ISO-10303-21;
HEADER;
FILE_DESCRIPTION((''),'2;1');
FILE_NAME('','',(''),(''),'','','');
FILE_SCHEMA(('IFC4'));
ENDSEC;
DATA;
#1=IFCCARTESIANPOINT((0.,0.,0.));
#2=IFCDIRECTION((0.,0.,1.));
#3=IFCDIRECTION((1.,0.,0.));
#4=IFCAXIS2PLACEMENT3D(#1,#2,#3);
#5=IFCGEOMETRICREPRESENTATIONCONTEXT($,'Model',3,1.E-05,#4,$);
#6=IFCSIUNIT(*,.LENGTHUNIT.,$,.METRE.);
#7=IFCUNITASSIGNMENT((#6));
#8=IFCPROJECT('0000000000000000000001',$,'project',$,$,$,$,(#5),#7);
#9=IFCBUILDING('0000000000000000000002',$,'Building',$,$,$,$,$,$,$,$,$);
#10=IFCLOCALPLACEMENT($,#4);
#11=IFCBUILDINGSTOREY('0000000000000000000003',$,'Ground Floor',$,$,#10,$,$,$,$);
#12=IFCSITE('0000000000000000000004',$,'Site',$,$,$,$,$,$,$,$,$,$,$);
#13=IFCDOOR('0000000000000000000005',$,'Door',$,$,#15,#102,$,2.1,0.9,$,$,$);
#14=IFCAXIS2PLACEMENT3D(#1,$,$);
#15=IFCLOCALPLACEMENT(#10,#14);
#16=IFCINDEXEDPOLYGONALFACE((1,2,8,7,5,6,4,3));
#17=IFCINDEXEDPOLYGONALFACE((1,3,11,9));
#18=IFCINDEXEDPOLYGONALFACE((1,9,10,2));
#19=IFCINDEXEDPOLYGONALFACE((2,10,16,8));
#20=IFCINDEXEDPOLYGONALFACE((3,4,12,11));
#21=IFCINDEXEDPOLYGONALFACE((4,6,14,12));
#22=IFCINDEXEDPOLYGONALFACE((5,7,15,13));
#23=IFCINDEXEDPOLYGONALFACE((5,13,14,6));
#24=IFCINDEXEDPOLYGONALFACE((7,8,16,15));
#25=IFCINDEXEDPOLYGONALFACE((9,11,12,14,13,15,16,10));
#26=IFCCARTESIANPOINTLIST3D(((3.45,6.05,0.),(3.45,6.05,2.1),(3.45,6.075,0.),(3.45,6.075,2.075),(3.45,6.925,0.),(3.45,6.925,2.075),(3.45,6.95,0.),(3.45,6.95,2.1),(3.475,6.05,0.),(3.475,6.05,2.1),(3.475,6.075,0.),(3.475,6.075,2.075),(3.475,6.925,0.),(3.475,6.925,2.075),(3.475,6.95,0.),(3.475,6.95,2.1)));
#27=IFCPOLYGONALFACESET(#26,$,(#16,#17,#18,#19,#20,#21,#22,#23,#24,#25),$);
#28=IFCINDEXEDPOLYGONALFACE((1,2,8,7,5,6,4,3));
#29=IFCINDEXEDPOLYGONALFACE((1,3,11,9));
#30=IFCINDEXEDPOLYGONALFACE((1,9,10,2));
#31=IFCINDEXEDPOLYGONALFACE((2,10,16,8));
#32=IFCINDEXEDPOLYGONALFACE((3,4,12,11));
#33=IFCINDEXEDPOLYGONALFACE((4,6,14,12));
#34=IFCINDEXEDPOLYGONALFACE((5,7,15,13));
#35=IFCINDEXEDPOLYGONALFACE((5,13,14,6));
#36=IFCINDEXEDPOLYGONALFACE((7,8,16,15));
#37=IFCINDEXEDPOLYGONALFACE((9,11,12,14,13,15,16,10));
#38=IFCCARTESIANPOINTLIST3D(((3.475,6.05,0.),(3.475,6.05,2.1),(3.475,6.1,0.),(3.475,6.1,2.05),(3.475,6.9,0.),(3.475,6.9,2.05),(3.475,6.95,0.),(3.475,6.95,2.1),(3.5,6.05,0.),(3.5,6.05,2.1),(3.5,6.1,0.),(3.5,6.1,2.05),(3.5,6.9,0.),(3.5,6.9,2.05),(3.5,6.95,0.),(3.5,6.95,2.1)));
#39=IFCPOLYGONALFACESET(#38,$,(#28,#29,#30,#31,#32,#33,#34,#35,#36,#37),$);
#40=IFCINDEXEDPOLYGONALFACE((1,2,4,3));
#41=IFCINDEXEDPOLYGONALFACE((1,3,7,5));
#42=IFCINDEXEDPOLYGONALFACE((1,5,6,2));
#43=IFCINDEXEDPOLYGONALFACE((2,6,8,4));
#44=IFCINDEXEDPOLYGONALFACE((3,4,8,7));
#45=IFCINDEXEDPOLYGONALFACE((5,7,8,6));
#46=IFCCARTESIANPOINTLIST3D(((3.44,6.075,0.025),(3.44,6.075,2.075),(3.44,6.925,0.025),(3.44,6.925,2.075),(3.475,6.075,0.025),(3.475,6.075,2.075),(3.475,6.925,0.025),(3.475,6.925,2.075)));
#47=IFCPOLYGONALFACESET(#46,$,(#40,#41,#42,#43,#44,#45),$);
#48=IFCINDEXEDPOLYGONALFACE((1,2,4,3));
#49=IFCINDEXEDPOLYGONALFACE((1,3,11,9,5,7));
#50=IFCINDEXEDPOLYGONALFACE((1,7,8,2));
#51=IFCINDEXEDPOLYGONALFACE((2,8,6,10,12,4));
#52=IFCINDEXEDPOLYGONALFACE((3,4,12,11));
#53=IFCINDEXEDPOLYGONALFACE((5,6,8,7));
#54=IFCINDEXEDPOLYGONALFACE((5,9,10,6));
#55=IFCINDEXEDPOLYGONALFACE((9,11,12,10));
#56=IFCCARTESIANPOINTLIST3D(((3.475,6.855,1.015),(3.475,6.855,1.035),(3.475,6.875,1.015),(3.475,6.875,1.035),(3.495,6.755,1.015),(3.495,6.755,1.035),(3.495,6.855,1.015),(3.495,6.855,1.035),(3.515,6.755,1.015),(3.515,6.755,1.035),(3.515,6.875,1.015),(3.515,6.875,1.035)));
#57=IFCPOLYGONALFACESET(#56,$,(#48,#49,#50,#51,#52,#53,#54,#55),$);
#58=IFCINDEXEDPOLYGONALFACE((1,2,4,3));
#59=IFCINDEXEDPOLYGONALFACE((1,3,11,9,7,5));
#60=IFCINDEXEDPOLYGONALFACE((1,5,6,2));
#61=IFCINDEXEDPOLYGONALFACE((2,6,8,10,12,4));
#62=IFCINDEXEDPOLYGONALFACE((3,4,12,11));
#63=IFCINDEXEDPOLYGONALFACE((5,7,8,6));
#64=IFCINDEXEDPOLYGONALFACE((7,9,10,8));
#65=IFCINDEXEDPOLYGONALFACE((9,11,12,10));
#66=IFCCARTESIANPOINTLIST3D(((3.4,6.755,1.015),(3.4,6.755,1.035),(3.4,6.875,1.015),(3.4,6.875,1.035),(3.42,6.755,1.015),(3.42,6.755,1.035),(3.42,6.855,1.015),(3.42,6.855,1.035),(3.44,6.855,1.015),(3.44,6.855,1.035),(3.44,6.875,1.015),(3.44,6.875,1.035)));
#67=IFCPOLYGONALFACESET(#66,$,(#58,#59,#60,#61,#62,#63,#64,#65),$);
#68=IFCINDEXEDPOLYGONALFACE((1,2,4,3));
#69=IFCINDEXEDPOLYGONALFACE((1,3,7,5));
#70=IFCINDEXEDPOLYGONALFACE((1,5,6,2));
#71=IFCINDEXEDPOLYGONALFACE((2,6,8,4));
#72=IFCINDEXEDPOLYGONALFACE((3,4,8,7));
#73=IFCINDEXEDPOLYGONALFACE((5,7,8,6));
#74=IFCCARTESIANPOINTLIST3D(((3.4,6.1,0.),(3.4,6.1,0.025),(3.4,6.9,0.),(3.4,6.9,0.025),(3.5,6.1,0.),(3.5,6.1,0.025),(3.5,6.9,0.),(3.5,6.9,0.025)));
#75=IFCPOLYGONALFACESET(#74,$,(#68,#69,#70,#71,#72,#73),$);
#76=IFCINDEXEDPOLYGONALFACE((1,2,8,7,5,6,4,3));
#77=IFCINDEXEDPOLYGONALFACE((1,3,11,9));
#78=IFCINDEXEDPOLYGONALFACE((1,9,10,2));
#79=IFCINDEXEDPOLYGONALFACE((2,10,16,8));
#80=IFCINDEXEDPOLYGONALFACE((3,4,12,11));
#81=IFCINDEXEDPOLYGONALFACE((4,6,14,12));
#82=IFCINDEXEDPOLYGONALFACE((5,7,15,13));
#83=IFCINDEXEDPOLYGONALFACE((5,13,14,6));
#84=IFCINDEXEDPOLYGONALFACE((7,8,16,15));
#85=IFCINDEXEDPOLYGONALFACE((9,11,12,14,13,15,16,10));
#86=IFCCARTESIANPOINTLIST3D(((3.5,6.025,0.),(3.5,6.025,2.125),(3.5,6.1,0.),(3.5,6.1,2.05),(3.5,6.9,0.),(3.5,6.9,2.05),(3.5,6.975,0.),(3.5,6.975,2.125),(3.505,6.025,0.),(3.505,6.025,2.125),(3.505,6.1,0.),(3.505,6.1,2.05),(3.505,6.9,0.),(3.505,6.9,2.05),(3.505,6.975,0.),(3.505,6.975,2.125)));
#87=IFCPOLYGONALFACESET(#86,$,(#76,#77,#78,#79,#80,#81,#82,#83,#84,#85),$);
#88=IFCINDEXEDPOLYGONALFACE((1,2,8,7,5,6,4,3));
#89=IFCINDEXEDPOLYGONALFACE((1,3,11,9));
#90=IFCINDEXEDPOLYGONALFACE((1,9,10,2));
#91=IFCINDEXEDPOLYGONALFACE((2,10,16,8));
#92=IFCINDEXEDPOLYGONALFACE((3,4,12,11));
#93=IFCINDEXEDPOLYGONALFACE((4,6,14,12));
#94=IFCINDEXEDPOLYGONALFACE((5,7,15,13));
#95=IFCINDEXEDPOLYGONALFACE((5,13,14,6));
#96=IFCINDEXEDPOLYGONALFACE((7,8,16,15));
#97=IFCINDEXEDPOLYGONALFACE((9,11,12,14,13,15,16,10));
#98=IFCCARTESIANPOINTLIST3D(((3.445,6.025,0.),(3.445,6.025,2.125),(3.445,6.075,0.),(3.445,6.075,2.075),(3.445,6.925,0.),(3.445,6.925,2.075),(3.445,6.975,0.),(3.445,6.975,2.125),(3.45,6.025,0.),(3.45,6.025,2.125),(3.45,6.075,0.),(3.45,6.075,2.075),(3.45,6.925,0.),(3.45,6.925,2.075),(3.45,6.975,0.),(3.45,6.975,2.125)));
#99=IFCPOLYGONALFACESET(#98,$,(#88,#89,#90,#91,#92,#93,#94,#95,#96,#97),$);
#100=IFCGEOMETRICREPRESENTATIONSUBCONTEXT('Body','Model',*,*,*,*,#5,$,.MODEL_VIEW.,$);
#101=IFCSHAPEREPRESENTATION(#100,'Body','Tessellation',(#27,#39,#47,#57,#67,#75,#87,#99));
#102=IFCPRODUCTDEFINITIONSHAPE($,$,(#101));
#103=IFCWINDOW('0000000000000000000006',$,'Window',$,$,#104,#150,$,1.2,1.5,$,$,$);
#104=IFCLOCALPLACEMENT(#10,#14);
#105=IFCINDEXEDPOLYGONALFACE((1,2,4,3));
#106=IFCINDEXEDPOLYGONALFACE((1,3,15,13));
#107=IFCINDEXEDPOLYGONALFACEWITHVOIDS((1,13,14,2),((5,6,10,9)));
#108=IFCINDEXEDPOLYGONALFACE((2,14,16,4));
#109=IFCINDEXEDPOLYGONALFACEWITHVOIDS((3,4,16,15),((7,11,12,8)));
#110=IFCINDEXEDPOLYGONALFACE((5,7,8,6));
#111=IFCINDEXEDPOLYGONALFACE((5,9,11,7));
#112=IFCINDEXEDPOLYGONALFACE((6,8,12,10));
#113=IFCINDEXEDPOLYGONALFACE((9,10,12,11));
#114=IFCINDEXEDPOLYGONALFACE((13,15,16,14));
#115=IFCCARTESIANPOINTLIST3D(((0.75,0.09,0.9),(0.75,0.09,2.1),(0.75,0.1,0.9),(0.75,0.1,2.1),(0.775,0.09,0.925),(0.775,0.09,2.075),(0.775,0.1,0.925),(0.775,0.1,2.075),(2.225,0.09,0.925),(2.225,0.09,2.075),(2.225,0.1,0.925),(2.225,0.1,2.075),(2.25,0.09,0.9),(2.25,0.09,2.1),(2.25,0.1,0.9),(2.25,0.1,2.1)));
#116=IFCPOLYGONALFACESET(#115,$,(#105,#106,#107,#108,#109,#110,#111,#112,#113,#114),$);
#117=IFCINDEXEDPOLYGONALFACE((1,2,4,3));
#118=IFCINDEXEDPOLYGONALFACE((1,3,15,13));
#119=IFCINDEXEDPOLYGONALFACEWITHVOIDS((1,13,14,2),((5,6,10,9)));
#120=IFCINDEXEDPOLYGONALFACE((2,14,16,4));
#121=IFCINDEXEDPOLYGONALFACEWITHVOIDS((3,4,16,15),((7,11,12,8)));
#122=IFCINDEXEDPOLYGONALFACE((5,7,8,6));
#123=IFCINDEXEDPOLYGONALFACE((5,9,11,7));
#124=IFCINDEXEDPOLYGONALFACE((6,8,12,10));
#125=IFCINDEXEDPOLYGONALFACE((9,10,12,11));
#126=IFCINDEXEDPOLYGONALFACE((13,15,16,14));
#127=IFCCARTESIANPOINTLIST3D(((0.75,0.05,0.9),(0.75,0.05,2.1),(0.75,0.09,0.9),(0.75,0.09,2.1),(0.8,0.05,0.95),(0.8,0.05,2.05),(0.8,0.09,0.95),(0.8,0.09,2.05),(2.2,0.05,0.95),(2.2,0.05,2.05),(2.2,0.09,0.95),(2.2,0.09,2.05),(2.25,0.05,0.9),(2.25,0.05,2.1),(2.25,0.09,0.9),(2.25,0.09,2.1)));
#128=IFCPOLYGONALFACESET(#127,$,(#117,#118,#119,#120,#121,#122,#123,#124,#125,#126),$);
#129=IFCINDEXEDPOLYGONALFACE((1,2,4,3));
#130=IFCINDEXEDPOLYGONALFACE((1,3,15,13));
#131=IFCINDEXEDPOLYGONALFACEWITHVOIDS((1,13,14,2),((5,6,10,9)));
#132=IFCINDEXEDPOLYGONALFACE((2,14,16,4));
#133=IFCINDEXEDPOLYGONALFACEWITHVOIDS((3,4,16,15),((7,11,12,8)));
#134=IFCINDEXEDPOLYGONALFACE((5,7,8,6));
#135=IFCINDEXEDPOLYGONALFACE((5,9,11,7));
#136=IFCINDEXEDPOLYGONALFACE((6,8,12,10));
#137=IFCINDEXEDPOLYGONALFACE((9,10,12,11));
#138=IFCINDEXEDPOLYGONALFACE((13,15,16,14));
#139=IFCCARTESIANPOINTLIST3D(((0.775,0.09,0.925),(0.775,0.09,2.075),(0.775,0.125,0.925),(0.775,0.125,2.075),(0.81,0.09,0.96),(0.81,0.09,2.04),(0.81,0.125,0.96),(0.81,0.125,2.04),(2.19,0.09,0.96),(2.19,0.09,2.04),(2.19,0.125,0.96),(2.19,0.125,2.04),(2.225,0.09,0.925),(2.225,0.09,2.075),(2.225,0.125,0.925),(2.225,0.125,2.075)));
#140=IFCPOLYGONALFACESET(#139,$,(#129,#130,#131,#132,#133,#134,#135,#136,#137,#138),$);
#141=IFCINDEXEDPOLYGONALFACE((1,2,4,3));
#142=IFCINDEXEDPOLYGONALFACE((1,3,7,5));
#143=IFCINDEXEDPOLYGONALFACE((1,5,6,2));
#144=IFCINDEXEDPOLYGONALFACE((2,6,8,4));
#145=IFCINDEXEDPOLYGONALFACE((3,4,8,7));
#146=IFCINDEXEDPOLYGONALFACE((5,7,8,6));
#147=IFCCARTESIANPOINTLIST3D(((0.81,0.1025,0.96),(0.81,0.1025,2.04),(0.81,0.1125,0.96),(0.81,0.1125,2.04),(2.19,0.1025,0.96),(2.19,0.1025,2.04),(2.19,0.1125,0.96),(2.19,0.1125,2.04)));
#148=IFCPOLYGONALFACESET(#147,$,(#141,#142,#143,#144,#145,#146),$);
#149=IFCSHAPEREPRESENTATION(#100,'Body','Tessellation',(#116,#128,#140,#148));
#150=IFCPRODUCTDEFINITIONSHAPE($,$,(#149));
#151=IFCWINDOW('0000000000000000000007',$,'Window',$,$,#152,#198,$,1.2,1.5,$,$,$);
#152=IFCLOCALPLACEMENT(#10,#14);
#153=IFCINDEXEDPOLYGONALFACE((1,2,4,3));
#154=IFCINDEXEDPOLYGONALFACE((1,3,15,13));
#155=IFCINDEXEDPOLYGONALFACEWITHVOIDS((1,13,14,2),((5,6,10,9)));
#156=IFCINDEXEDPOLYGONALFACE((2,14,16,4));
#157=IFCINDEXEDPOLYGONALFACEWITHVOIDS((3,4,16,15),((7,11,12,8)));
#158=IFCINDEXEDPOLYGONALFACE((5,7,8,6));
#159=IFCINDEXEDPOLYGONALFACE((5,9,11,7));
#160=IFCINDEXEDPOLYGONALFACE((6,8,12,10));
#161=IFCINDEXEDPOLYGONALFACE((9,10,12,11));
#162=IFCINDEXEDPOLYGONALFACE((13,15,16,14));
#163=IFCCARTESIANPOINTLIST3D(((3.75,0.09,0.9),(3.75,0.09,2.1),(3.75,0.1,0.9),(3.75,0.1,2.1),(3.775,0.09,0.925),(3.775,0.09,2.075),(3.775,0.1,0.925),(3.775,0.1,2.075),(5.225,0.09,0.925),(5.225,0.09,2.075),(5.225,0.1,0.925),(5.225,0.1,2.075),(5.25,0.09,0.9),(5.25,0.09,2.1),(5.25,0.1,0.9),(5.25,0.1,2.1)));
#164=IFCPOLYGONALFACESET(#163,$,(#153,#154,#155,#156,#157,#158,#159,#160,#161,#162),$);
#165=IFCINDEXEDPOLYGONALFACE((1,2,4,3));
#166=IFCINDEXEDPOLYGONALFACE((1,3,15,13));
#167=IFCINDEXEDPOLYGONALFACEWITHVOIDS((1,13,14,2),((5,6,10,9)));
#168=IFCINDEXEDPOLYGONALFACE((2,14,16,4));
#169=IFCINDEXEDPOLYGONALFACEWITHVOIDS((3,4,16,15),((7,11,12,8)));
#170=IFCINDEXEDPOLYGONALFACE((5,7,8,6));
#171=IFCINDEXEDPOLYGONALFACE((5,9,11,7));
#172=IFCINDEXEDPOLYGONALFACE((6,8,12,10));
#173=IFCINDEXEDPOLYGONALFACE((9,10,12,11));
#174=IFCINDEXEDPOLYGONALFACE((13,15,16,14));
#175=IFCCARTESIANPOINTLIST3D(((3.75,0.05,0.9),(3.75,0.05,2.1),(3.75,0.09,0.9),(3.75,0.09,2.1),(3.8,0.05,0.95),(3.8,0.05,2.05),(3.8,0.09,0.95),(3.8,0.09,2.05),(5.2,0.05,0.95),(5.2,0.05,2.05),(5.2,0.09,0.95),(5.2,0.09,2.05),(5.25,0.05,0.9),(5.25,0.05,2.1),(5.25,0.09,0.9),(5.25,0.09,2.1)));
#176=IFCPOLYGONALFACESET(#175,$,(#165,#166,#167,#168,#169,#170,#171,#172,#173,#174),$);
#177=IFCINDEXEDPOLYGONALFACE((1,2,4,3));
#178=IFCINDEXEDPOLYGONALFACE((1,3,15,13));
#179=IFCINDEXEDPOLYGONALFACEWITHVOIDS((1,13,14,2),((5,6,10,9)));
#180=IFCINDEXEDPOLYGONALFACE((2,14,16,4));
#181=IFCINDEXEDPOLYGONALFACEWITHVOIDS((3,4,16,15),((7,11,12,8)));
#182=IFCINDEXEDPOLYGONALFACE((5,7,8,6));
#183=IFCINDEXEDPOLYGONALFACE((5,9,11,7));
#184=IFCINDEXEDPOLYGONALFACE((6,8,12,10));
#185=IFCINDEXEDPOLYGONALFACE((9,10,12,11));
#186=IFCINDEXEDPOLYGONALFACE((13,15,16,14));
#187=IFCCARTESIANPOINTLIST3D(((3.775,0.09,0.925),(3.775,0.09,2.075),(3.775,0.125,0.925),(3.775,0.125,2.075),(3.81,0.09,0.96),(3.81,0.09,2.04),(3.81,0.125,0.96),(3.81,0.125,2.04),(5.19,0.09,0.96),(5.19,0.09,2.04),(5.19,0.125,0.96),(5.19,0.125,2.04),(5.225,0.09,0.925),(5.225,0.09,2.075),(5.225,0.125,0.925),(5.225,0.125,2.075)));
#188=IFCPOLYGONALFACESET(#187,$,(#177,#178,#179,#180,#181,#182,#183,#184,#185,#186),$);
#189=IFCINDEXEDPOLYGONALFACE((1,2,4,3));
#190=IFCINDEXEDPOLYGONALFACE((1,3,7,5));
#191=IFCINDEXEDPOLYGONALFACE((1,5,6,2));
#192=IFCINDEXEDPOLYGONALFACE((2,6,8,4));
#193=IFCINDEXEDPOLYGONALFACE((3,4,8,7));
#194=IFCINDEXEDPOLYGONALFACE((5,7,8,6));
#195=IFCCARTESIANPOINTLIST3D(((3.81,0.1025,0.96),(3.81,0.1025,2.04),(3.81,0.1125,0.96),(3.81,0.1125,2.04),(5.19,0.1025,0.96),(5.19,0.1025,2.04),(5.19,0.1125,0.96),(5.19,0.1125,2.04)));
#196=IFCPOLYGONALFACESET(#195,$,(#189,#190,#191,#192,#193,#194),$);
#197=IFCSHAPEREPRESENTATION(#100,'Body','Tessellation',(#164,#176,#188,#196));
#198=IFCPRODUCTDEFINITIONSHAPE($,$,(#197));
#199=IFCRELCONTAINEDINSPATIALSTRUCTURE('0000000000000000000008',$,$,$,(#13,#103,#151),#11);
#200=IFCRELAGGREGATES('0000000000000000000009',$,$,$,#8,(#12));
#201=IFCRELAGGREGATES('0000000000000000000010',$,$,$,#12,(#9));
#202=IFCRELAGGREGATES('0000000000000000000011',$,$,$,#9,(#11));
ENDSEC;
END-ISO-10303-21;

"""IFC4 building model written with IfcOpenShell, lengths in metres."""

from ifc_helpers import new_model, si_unit, frame, origin_with_axes, place, context, subcontext, project, spatial, line, indexed_curve, outline, extrude, element, save


model = new_model("IFC4")

# Units and contexts
model_context = context("Model", 3, precision=1e-05, world=origin_with_axes())
body_context = subcontext(model_context, "Body", "Model", "MODEL_VIEW")
ifc_project = project(units=[si_unit("LENGTHUNIT", "METRE")], contexts=[model_context])

# Site, building, storey
site = spatial("IfcSite", under=ifc_project, Name="Site")
building = spatial("IfcBuilding", under=site, Name="Building")
storey_placement = place(None, origin_with_axes())
storey = spatial("IfcBuildingStorey", under=building, at=storey_placement, Name="Ground Floor")

# Door
door_1_placement = place(storey_placement, frame((3.5, 6.05, 0.0), z_axis=(0.0, 0.0, 1.0), x_axis=(0.0, 1.0, 0.0)))
element("IfcDoor", 1, at=door_1_placement, inside=storey, Name="Door", OverallHeight=2.1, OverallWidth=0.9, context=body_context, shape_type="SweptSolid", body=[
    extrude(outline(indexed_curve([(0.0, 0.0), (0.0, 2.1), (0.9, 2.1), (0.9, 0.0), (0.875, 0.0), (0.875, 2.075), (0.025, 2.075), (0.025, 0.0)], segments=[line(1, 2, 3, 4, 5, 6, 7, 8, 1)])), frame((0.0, 0.025, 0.0), z_axis=(0.0, -1.0, 0.0), x_axis=(1.0, 0.0, 0.0)), (0.0, 0.0, -1.0), 0.025),
    extrude(outline(indexed_curve([(0.0, 0.0), (0.0, 2.1), (0.9, 2.1), (0.9, 0.0), (0.85, 0.0), (0.85, 2.05), (0.05, 2.05), (0.05, 0.0)], segments=[line(1, 2, 3, 4, 5, 6, 7, 8, 1)])), frame((0.0, 0.0, 0.0), z_axis=(0.0, -1.0, 0.0), x_axis=(1.0, 0.0, 0.0)), (0.0, 0.0, -1.0), 0.025),
    extrude(outline(indexed_curve([(0.0, 0.0), (0.85, 0.0), (0.85, 0.035), (0.0, 0.035)], segments=[line(1, 2, 3, 4, 1)])), frame((0.025, 0.025, 0.025), z_axis=(0.0, 0.0, 1.0), x_axis=(1.0, 0.0, 0.0)), (0.0, 0.0, 1.0), 2.05),
    extrude(outline(indexed_curve([(0.0, 0.0), (0.0, -0.04), (-0.12, -0.04), (-0.12, -0.02), (-0.02, -0.02), (-0.02, 0.0)], segments=[line(1, 2, 3, 4, 5, 6, 1)])), frame((0.825, 0.025, 1.015), z_axis=(0.0, 0.0, 1.0), x_axis=(1.0, 0.0, 0.0)), (0.0, 0.0, 1.0), 0.02),
    extrude(outline(indexed_curve([(0.0, 0.0), (0.0, 0.04), (-0.12, 0.04), (-0.12, 0.02), (-0.02, 0.02), (-0.02, 0.0)], segments=[line(1, 2, 3, 4, 5, 6, 1)])), frame((0.825, 0.06, 1.015), z_axis=(0.0, 0.0, 1.0), x_axis=(1.0, 0.0, 0.0)), (0.0, 0.0, 1.0), 0.02),
    extrude(outline(indexed_curve([(0.0, 0.0), (0.8, 0.0), (0.8, 0.1), (0.0, 0.1)], segments=[line(1, 2, 3, 4, 1)])), frame((0.05, 0.0, 0.0), z_axis=(0.0, 0.0, 1.0), x_axis=(1.0, 0.0, 0.0)), (0.0, 0.0, 1.0), 0.025),
    extrude(outline(indexed_curve([(0.0, 0.0), (0.0, 2.125), (0.95, 2.125), (0.95, 0.0), (0.875, 0.0), (0.875, 2.05), (0.075, 2.05), (0.075, 0.0)], segments=[line(1, 2, 3, 4, 5, 6, 7, 8, 1)])), frame((-0.025, -0.005, 0.0), z_axis=(0.0, -1.0, 0.0), x_axis=(1.0, 0.0, 0.0)), (0.0, 0.0, -1.0), 0.005),
    extrude(outline(indexed_curve([(0.0, 0.0), (0.0, 2.125), (0.95, 2.125), (0.95, 0.0), (0.9, 0.0), (0.9, 2.075), (0.05, 2.075), (0.05, 0.0)], segments=[line(1, 2, 3, 4, 5, 6, 7, 8, 1)])), frame((-0.025, 0.05, 0.0), z_axis=(0.0, -1.0, 0.0), x_axis=(1.0, 0.0, 0.0)), (0.0, 0.0, -1.0), 0.005),
])

# Windows
for number, where, z_axis, x_axis, name in (
    (2, (0.75, 0.0, 0.9), (0.0, 0.0, 1.0), (1.0, 0.0, 0.0), "Window"),
    (3, (3.75, 0.0, 0.9), (0.0, 0.0, 1.0), (1.0, 0.0, 0.0), "Window"),
):
    element("IfcWindow", number, at=place(storey_placement, frame(where, z_axis=z_axis, x_axis=x_axis)), inside=storey, Name=name, OverallHeight=1.2, OverallWidth=1.5, context=body_context, shape_type="SweptSolid", body=[
        extrude(outline(indexed_curve([(0.0, 0.0), (1.5, 0.0), (1.5, 1.2), (0.0, 1.2)], segments=[line(1, 2, 3, 4, 1)]), holes=[indexed_curve([(0.025, 0.025), (1.475, 0.025), (1.475, 1.175), (0.025, 1.175)], segments=[line(1, 2, 3, 4, 1)])]), frame((0.0, 0.09, 0.0), z_axis=(0.0, -1.0, 0.0), x_axis=(1.0, 0.0, 0.0)), (0.0, 0.0, -1.0), 0.01),
        extrude(outline(indexed_curve([(0.0, 0.0), (1.5, 0.0), (1.5, 1.2), (0.0, 1.2)], segments=[line(1, 2, 3, 4, 1)]), holes=[indexed_curve([(0.05, 0.05), (1.45, 0.05), (1.45, 1.15), (0.05, 1.15)], segments=[line(1, 2, 3, 4, 1)])]), frame((0.0, 0.05, 0.0), z_axis=(0.0, -1.0, 0.0), x_axis=(1.0, 0.0, 0.0)), (0.0, 0.0, -1.0), 0.04),
        extrude(outline(indexed_curve([(0.0, 0.0), (1.45, 0.0), (1.45, 1.15), (0.0, 1.15)], segments=[line(1, 2, 3, 4, 1)]), holes=[indexed_curve([(0.035, 0.035), (1.415, 0.035), (1.415, 1.115), (0.035, 1.115)], segments=[line(1, 2, 3, 4, 1)])]), frame((0.025, 0.09, 0.025), z_axis=(0.0, -1.0, 0.0), x_axis=(1.0, 0.0, 0.0)), (0.0, 0.0, -1.0), 0.035),
        extrude(outline(indexed_curve([(0.035, 0.035), (1.415, 0.035), (1.415, 1.115), (0.035, 1.115)], segments=[line(1, 2, 3, 4, 1)])), frame((0.025, 0.1025, 0.025), z_axis=(0.0, -1.0, 0.0), x_axis=(1.0, 0.0, 0.0)), (0.0, 0.0, -1.0), 0.01),
    ])

save(model, "model.ifc")
